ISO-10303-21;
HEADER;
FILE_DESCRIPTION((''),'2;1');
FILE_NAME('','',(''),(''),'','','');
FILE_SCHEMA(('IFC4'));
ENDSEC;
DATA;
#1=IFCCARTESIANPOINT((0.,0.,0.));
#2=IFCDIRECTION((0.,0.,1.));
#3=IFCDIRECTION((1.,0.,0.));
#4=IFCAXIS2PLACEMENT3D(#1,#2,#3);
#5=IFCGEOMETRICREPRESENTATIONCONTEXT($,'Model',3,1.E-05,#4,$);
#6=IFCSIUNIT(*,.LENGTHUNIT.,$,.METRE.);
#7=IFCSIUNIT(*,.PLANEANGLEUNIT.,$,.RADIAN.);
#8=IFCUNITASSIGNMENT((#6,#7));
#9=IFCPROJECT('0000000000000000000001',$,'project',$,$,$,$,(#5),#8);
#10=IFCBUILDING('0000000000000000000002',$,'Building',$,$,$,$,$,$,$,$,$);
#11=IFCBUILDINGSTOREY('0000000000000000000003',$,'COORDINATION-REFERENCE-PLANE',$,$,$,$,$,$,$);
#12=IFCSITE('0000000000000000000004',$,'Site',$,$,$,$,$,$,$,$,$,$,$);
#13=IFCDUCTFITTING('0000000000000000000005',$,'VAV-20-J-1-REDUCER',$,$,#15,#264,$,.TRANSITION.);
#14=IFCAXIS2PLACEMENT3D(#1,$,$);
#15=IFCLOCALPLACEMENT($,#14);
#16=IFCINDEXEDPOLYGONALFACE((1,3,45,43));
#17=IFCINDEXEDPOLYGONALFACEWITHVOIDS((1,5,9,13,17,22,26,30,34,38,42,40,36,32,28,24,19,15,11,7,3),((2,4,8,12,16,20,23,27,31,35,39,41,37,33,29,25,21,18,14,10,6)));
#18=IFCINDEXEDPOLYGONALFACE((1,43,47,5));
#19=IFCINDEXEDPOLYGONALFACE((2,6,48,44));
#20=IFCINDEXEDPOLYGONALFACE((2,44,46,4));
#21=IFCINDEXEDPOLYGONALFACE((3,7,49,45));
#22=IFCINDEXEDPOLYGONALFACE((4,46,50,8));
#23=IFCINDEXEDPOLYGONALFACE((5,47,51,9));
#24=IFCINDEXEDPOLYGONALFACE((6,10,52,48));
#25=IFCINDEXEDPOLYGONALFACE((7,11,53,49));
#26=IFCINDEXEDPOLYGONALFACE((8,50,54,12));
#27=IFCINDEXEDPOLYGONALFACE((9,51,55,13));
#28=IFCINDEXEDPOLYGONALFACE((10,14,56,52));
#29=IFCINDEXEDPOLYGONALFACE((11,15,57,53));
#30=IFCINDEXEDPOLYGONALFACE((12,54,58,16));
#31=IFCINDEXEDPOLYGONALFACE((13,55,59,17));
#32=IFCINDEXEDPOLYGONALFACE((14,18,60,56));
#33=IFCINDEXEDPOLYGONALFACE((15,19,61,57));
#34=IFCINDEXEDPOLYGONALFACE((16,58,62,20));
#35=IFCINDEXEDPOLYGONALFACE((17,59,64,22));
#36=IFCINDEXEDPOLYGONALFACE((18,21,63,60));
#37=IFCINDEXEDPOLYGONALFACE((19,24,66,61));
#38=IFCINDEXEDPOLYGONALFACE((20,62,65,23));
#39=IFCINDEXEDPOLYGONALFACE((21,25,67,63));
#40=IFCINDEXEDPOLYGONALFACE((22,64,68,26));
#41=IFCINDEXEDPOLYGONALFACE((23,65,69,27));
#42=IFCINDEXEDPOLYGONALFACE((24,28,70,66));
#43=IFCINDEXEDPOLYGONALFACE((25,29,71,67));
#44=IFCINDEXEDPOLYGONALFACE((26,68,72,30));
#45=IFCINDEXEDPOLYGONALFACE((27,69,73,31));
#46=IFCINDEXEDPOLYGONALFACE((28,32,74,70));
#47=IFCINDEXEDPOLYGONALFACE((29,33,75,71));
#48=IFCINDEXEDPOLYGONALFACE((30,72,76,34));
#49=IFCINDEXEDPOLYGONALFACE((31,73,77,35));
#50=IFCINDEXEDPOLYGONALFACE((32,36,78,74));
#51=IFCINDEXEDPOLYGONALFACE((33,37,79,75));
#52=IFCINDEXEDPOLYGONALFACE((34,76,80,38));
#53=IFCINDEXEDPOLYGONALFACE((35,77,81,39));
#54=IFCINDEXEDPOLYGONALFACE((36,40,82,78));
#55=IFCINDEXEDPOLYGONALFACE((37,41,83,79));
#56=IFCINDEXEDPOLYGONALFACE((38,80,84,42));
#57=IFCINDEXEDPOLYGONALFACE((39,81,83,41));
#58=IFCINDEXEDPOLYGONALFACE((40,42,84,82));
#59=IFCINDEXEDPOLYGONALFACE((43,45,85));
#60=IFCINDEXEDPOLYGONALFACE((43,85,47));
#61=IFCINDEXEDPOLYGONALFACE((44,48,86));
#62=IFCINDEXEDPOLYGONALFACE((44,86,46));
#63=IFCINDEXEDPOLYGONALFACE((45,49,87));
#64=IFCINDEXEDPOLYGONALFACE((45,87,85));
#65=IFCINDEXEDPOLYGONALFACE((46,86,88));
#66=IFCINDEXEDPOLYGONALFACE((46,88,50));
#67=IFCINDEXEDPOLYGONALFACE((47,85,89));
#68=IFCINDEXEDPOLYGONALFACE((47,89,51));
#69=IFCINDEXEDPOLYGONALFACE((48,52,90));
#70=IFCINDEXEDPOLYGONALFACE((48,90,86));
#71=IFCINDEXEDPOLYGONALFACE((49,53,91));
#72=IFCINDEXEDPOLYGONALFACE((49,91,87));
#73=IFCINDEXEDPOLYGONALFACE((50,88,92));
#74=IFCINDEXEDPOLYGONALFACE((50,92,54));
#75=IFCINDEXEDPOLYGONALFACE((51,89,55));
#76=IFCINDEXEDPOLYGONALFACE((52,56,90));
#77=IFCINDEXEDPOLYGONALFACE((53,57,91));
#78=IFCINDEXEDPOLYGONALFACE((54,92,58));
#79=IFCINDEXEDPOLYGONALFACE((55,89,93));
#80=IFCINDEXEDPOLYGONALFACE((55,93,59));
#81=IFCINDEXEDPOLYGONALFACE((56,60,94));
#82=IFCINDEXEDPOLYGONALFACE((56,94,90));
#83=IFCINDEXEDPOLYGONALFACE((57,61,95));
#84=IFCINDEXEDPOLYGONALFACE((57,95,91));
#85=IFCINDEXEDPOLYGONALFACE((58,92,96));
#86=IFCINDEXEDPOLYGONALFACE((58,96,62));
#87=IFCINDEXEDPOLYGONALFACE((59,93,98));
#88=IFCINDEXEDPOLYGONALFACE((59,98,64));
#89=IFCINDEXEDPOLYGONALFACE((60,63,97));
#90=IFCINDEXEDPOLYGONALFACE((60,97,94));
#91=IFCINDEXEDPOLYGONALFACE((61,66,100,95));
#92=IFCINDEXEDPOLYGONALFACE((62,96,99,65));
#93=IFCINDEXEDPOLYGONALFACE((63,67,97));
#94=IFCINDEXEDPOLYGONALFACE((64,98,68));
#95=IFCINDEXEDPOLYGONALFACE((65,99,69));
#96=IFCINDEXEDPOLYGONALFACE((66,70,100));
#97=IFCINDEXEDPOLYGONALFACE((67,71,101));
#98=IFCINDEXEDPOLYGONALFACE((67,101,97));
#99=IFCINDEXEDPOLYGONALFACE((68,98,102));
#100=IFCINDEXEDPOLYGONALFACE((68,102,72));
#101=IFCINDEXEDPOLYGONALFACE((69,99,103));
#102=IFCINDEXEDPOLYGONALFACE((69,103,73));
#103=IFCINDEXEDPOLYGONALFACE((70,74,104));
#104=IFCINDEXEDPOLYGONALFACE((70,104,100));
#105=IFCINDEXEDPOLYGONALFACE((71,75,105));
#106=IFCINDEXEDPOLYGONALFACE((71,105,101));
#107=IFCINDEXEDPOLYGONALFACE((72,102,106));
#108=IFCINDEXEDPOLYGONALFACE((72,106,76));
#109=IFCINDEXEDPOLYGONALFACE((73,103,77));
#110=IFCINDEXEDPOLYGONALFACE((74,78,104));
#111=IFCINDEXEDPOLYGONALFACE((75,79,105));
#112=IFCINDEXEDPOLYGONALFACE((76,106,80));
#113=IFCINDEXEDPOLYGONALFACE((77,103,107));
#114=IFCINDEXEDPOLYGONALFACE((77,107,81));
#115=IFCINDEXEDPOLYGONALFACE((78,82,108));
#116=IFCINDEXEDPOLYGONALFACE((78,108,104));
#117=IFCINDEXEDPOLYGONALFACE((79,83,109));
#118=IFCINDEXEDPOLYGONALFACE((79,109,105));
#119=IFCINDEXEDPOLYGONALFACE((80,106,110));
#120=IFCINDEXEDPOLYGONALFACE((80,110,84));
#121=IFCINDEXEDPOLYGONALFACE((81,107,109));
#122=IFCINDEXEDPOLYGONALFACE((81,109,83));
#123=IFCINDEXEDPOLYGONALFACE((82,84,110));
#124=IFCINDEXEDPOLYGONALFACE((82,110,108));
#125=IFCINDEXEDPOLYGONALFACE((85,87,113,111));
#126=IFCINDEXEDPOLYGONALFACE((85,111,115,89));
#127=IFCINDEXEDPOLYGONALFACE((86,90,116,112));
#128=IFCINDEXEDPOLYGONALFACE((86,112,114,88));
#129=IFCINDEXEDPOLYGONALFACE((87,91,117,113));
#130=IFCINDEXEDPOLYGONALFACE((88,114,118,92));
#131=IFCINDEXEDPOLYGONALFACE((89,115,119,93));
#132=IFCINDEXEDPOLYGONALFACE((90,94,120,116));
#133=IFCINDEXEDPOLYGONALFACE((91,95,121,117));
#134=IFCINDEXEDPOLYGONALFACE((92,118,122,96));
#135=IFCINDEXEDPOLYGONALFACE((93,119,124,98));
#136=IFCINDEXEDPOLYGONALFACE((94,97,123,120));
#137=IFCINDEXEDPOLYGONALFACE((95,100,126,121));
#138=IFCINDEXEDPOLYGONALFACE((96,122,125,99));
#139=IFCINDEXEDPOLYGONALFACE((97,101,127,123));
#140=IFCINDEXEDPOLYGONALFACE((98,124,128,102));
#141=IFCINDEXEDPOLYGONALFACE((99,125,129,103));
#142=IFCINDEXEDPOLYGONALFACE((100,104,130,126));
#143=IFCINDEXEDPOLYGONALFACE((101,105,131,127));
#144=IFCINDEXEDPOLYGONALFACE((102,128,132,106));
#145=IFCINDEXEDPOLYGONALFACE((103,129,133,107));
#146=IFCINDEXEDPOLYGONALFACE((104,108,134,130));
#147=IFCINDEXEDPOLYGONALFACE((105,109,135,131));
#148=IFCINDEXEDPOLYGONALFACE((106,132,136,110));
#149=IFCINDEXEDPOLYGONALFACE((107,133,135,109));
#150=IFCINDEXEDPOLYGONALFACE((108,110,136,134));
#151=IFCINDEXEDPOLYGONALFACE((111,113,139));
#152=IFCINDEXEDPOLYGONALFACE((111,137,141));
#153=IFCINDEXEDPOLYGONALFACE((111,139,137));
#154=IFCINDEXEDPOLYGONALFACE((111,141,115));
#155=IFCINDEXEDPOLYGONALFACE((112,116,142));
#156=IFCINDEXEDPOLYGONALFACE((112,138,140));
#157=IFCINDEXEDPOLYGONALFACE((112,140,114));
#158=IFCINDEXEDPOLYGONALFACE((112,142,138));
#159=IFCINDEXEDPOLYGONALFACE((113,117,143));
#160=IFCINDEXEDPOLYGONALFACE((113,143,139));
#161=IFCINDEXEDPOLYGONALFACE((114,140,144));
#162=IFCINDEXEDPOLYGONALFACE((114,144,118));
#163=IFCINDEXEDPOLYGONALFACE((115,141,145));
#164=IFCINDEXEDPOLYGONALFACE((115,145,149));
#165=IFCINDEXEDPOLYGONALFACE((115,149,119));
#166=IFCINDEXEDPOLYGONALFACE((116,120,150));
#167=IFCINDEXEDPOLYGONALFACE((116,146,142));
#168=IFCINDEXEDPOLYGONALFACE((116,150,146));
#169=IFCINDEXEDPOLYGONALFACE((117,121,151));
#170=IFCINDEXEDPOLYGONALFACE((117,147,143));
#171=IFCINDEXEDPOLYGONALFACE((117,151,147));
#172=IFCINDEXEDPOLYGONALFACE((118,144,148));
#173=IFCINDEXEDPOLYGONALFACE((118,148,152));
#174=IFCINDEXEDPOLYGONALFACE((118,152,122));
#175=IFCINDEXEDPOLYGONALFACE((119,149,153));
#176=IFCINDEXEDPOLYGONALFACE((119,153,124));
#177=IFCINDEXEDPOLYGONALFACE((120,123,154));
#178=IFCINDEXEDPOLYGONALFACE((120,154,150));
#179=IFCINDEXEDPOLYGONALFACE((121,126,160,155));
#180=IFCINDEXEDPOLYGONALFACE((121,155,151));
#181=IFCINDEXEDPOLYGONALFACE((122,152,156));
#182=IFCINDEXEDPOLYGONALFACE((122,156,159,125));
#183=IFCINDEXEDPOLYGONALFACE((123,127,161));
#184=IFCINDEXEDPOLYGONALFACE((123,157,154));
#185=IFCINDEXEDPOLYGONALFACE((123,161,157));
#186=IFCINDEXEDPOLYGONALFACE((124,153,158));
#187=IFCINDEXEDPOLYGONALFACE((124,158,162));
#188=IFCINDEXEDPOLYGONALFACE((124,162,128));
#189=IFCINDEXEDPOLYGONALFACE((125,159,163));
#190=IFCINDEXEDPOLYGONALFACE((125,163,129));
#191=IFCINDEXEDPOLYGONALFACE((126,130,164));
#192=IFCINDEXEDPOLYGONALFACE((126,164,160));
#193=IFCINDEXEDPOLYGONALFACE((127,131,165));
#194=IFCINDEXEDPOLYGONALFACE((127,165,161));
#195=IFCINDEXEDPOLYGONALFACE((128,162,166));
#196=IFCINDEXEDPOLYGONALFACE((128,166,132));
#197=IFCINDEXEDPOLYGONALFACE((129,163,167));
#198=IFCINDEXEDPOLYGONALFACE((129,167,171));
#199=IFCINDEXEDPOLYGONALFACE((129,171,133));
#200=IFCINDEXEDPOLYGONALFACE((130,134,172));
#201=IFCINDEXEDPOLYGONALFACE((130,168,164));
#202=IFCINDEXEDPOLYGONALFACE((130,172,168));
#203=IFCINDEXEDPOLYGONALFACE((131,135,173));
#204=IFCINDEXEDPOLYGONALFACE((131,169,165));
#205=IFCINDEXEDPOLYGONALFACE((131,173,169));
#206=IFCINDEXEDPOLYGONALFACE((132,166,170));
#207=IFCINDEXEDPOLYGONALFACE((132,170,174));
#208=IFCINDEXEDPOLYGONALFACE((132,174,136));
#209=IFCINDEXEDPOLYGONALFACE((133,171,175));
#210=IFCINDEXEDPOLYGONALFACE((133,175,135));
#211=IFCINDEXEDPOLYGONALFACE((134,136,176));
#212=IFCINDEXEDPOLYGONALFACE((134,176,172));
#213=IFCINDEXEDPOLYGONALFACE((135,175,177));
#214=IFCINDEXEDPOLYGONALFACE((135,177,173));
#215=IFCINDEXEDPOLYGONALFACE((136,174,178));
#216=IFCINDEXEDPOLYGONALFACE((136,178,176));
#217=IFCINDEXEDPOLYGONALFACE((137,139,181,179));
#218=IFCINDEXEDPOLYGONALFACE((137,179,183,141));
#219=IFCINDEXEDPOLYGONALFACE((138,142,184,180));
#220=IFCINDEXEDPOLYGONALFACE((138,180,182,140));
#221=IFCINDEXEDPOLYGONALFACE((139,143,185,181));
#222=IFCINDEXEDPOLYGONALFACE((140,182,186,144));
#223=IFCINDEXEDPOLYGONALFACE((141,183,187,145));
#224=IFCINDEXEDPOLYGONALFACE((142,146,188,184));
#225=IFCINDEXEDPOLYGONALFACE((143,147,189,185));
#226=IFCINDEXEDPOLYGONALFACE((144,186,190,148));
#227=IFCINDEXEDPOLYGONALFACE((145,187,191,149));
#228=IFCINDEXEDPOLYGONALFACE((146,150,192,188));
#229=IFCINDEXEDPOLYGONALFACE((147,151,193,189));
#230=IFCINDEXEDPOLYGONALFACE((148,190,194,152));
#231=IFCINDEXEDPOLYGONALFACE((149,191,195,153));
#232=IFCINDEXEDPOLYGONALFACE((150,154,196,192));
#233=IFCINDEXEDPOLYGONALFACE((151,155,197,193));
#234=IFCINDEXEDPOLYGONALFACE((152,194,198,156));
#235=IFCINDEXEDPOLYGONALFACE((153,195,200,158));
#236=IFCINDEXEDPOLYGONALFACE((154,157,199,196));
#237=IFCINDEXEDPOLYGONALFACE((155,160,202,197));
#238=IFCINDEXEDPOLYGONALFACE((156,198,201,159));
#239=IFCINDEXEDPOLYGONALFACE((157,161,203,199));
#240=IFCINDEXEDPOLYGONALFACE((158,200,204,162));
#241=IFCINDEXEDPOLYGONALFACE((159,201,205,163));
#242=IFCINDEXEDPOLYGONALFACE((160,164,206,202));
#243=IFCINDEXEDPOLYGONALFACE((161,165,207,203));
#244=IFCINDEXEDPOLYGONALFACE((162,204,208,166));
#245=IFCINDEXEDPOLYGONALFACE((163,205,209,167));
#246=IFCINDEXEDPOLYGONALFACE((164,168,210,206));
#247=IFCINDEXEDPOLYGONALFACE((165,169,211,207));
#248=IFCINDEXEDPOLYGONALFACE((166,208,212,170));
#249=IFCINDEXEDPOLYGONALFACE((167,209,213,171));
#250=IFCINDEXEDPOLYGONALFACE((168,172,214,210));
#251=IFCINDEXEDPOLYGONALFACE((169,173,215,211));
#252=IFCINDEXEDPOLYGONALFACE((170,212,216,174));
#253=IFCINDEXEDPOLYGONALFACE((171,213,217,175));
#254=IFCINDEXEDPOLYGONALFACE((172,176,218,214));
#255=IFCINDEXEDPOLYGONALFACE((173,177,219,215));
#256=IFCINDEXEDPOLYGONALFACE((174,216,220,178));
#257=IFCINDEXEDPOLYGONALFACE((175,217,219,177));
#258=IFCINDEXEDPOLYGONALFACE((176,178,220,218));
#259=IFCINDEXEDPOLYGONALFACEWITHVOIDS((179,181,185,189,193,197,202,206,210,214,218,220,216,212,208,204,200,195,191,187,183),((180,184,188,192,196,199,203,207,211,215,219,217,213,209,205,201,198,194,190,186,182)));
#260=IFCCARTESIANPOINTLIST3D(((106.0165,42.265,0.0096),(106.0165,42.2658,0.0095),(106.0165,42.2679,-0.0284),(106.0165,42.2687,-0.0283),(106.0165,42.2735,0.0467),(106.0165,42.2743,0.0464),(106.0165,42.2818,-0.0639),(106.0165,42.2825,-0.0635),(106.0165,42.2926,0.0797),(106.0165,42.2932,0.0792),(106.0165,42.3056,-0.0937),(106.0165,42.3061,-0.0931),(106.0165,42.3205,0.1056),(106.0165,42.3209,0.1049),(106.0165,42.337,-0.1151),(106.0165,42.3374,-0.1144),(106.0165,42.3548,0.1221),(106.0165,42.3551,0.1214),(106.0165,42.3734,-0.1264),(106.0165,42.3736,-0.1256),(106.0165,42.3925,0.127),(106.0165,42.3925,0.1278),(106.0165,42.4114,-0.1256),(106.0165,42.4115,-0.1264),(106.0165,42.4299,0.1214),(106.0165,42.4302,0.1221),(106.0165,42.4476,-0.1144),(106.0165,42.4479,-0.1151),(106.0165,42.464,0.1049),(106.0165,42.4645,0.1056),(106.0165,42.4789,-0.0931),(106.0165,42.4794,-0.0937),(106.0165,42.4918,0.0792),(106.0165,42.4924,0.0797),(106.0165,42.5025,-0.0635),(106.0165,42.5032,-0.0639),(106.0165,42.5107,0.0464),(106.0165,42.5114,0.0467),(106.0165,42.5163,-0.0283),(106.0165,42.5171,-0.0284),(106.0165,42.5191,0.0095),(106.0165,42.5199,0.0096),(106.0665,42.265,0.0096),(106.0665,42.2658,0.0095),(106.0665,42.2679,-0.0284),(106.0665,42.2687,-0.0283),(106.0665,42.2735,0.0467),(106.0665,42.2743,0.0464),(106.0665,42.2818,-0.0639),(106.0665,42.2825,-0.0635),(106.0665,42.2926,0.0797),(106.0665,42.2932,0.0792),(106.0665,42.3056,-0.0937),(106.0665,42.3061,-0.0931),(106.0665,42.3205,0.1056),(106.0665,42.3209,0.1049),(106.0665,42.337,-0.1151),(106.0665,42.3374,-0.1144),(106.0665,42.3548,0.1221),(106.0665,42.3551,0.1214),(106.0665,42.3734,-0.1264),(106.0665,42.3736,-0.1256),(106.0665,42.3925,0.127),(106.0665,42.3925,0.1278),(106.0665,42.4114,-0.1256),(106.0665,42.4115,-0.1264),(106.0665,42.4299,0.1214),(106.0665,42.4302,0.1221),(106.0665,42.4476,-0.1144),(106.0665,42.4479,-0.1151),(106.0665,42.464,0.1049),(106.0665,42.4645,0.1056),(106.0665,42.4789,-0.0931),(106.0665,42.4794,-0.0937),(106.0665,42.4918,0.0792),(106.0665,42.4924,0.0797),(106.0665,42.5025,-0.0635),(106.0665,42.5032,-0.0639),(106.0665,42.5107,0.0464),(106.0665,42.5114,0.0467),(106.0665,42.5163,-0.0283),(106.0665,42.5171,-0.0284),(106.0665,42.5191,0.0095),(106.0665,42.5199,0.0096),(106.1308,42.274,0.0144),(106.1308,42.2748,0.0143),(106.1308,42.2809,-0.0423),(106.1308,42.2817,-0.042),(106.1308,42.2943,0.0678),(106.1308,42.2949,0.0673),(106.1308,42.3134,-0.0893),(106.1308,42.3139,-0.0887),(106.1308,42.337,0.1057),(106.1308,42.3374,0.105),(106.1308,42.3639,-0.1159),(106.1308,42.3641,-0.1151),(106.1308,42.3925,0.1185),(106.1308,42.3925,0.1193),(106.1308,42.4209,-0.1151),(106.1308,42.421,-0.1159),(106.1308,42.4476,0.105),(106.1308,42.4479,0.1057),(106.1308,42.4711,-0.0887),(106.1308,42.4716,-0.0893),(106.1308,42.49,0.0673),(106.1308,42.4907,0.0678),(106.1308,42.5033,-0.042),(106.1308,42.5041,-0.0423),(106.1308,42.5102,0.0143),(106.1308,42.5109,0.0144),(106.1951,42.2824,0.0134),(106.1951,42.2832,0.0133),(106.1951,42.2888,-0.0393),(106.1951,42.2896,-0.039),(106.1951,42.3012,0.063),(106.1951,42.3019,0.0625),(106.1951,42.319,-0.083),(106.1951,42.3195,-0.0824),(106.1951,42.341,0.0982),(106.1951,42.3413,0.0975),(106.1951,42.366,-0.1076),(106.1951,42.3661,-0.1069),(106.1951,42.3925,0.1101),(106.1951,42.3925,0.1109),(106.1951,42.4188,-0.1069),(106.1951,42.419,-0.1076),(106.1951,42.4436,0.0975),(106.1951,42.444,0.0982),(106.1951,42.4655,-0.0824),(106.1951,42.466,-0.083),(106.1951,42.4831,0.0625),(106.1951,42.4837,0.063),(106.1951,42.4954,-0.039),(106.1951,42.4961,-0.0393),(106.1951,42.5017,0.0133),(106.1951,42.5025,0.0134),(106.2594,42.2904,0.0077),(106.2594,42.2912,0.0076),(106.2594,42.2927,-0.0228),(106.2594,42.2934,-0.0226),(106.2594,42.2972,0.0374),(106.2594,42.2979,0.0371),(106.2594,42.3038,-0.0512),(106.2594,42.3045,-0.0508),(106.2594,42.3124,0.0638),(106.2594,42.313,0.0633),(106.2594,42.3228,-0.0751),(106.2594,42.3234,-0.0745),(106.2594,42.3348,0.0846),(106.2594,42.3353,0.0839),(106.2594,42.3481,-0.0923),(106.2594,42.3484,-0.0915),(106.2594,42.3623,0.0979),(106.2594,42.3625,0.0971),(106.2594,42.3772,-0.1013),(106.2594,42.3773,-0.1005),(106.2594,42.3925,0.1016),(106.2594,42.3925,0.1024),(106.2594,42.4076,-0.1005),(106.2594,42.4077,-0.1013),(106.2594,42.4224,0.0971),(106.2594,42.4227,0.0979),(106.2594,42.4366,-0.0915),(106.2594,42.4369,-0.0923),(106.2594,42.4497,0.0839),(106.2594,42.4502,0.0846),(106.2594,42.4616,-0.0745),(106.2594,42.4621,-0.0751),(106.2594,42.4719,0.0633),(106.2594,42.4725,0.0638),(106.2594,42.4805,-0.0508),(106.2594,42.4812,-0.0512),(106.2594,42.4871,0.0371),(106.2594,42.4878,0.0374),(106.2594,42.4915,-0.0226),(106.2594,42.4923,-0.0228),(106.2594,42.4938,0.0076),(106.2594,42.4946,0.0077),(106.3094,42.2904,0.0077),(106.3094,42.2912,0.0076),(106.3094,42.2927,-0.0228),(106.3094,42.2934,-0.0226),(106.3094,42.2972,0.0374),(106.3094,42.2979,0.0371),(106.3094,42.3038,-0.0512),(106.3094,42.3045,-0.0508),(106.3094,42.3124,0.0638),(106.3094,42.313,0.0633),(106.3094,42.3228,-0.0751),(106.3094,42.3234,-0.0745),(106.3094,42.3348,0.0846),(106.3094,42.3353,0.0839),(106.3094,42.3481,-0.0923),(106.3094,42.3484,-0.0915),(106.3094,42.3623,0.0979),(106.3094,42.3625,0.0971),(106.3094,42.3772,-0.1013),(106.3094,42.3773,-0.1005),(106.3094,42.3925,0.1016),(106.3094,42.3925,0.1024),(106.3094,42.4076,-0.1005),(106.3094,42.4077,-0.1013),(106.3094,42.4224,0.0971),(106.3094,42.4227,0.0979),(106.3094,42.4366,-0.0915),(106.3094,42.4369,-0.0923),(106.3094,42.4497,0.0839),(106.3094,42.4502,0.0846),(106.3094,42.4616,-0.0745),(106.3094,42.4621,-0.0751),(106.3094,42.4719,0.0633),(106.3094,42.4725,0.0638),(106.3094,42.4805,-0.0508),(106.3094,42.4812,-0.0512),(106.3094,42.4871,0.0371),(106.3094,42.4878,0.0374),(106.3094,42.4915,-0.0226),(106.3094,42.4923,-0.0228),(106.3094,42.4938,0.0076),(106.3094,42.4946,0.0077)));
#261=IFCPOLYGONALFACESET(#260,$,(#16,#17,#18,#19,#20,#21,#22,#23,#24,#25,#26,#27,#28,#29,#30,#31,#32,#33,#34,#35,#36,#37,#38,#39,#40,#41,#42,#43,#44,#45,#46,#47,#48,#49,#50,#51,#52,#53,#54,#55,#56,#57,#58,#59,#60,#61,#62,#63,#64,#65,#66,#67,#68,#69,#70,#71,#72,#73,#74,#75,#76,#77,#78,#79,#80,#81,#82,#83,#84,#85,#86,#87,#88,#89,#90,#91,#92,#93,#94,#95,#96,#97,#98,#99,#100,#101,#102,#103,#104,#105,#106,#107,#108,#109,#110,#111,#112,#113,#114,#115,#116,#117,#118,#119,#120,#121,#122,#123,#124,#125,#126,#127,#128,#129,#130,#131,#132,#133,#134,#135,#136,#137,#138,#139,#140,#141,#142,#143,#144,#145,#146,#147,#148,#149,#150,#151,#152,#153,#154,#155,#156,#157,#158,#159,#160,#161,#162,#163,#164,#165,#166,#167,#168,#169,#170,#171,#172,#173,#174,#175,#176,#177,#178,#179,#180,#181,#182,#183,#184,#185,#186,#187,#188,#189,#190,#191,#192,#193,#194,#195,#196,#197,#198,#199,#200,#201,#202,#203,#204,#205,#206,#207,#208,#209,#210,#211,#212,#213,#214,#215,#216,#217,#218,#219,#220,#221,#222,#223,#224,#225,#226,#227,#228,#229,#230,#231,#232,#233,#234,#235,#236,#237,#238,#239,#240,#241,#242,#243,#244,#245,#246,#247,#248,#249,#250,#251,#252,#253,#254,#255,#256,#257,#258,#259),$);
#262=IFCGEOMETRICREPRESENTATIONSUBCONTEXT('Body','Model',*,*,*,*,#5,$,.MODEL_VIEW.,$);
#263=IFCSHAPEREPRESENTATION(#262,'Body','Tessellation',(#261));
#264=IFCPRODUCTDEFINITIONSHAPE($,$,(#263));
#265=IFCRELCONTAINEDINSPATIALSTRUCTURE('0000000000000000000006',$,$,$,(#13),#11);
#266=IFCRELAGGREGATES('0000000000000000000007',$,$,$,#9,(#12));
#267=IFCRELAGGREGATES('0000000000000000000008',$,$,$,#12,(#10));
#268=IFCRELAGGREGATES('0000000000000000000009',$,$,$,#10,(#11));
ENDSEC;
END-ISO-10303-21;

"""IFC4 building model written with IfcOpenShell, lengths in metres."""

from ifc_helpers import new_model, entity, si_unit, frame, origin_with_axes, place, context, subcontext, project, spatial, element, save


model = new_model("IFC4")

# Units and contexts
model_context_1 = context("Model", 3, precision=1e-05, world=origin_with_axes())
body_context_1 = subcontext(model_context_1, "Body", "Model", "MODEL_VIEW")
ifc_project = project(units=[si_unit("LENGTHUNIT", "METRE"), si_unit("PLANEANGLEUNIT", "RADIAN")], contexts=[model_context_1])

# Site, building, storey
site = spatial("IfcSite", under=ifc_project, Name="Site")
building = spatial("IfcBuilding", under=site, Name="Building")
storey = spatial("IfcBuildingStorey", under=building, Name="COORDINATION-REFERENCE-PLANE")

# Duct fitting
for number, where, z_axis, x_axis, name in (
    (1, (106.0165, 42.3925, 0.0), (0.0, 1.0, 0.0), (0.0, 0.0, 1.0), "VAV-20-J-1-REDUCER"),
):
    element("IfcDuctFitting", number, at=place(None, frame(where, z_axis=z_axis, x_axis=x_axis)), inside=storey, Name=name, PredefinedType="TRANSITION", context=body_context_1, shape_type="SweptSolid", body=[
        entity("IfcRevolvedAreaSolid", entity("IfcArbitraryClosedProfileDef", "AREA", None, entity("IfcPolyline", [entity("IfcCartesianPoint", [0.1278, 0.0]), entity("IfcCartesianPoint", [0.1278, 0.05]), entity("IfcCartesianPoint", [0.1024, 0.2429]), entity("IfcCartesianPoint", [0.1024, 0.2929]), entity("IfcCartesianPoint", [0.1016, 0.2929]), entity("IfcCartesianPoint", [0.1016, 0.2429]), entity("IfcCartesianPoint", [0.127, 0.05]), entity("IfcCartesianPoint", [0.127, 0.0]), entity("IfcCartesianPoint", [0.1278, 0.0])])), entity("IfcAxis2Placement3D", entity("IfcCartesianPoint", [0.0, 0.0, 0.0])), entity("IfcAxis1Placement", entity("IfcCartesianPoint", [0.0, 0.0, 0.0]), entity("IfcDirection", [0.0, 1.0, 0.0])), 6.283185),
    ])

save(model, "model.ifc")
